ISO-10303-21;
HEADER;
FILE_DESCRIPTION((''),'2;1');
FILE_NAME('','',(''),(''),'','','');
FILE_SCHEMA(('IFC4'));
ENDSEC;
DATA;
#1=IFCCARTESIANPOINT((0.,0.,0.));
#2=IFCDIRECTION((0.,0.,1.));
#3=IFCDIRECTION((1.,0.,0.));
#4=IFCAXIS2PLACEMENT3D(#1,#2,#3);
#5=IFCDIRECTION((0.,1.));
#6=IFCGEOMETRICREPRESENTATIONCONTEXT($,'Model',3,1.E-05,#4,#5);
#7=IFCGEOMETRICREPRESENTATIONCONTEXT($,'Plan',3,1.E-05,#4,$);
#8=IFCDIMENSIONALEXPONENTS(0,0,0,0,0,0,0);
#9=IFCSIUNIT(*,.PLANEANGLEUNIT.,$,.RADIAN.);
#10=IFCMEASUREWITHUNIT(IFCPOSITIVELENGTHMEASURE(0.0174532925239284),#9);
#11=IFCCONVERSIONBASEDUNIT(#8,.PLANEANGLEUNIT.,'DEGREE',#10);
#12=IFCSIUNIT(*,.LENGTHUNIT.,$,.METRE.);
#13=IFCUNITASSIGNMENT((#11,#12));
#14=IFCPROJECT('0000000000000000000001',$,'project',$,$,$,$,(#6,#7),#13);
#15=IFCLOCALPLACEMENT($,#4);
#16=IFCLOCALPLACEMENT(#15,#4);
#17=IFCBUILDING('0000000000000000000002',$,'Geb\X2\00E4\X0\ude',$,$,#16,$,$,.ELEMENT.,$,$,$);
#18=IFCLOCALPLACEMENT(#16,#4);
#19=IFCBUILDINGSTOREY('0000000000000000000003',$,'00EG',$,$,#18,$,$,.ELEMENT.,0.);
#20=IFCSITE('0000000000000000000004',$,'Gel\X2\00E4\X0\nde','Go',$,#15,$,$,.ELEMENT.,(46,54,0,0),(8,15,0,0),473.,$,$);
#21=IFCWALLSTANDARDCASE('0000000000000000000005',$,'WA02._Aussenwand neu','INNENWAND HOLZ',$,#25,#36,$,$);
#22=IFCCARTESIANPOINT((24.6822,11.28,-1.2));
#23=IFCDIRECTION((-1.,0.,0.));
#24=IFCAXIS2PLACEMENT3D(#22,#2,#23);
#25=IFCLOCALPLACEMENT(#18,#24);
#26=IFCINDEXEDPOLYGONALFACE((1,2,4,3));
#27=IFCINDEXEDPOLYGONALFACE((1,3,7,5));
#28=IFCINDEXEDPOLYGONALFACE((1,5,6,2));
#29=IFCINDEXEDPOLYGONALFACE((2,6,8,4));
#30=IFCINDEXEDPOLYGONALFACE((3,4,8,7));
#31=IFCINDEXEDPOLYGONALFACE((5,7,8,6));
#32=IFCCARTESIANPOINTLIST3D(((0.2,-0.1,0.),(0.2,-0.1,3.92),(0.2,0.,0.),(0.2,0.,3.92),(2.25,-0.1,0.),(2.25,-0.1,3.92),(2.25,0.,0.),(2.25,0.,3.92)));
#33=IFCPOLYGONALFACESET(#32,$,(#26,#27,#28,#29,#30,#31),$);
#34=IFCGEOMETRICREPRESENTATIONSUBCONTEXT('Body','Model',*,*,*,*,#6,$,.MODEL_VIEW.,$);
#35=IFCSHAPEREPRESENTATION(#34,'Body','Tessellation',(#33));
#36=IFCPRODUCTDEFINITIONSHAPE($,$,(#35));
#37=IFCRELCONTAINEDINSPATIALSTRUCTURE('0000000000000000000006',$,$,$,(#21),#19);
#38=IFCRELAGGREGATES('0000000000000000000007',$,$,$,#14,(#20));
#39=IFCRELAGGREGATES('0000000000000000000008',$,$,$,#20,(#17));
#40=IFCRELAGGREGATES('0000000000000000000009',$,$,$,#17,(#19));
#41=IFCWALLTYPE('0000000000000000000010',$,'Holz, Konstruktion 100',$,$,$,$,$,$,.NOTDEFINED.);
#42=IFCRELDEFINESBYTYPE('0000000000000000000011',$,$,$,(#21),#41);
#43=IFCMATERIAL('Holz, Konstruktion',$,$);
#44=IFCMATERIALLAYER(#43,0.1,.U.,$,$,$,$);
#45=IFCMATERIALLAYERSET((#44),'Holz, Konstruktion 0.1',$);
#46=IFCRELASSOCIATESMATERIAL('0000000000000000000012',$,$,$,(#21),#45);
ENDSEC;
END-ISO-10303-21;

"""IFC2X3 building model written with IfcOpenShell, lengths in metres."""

from ifc_helpers import new_model, entity, si_unit, converted_unit, direction, frame, origin_with_axes, place, context, subcontext, project, spatial, polyline, outline, extrude, material, layer, layer_set, layer_usage, type_object, element, save


model = new_model("IFC2X3")

# Units and contexts
model_context = context("Model", 3, precision=1e-05, world=origin_with_axes(), true_north=direction((0.0, 1.0)))
plan_context = context("Plan", 3, precision=1e-05, world=origin_with_axes())
body_context = subcontext(model_context, "Body", "Model", "MODEL_VIEW")
ifc_project = project(units=[converted_unit("PLANEANGLEUNIT", "DEGREE", entity("IfcPositiveLengthMeasure", 0.0174532925239284), si_unit("PLANEANGLEUNIT", "RADIAN"), dimensions=[0, 0, 0, 0, 0, 0, 0]), si_unit("LENGTHUNIT", "METRE")], contexts=[model_context, plan_context])

# Site, building, storey
site_placement = place(None, origin_with_axes())
site = spatial("IfcSite", under=ifc_project, at=site_placement, Name="Gelände", Description="Go", CompositionType="ELEMENT", RefLatitude=(46, 54, 0, 0), RefLongitude=(8, 15, 0, 0), RefElevation=473.0)
building_placement = place(site_placement, origin_with_axes())
building = spatial("IfcBuilding", under=site, at=building_placement, Name="Gebäude", CompositionType="ELEMENT")
storey_placement = place(building_placement, origin_with_axes())
storey = spatial("IfcBuildingStorey", under=building, at=storey_placement, Name="00EG", CompositionType="ELEMENT", Elevation=0.0)

# Shared definitions
ifc_material_1 = material(Name="Holz, Konstruktion")

# Wall
ifc_layer_1 = layer(ifc_material_1, 0.1, ventilated="UNKNOWN")
ifc_layer_set_1 = layer_set([ifc_layer_1], Name="Holz, Konstruktion 0.1")
ifc_layer_usage_1 = layer_usage(ifc_layer_set_1, "AXIS2", "NEGATIVE", 0.0)
wall_type_1 = type_object("IfcWallType", Name="Holz, Konstruktion 100", PredefinedType="NOTDEFINED")
wall_1_placement = place(storey_placement, frame((24.6822, 11.28, -1.2), z_axis=(0.0, 0.0, 1.0), x_axis=(-1.0, 0.0, 0.0)))
element("IfcWallStandardCase", 1, at=wall_1_placement, inside=storey, type_object=wall_type_1, material=ifc_layer_usage_1, Name="WA02._Aussenwand neu", Description="INNENWAND HOLZ", context=body_context, shape_type="SweptSolid", body=[
    extrude(outline(polyline([(0.2, -0.1), (2.25, -0.1), (2.25, 0.0), (0.2, 0.0), (0.2, -0.1)])), origin_with_axes(), (0.0, 0.0, 1.0), 3.92),
])

save(model, "model.ifc")
